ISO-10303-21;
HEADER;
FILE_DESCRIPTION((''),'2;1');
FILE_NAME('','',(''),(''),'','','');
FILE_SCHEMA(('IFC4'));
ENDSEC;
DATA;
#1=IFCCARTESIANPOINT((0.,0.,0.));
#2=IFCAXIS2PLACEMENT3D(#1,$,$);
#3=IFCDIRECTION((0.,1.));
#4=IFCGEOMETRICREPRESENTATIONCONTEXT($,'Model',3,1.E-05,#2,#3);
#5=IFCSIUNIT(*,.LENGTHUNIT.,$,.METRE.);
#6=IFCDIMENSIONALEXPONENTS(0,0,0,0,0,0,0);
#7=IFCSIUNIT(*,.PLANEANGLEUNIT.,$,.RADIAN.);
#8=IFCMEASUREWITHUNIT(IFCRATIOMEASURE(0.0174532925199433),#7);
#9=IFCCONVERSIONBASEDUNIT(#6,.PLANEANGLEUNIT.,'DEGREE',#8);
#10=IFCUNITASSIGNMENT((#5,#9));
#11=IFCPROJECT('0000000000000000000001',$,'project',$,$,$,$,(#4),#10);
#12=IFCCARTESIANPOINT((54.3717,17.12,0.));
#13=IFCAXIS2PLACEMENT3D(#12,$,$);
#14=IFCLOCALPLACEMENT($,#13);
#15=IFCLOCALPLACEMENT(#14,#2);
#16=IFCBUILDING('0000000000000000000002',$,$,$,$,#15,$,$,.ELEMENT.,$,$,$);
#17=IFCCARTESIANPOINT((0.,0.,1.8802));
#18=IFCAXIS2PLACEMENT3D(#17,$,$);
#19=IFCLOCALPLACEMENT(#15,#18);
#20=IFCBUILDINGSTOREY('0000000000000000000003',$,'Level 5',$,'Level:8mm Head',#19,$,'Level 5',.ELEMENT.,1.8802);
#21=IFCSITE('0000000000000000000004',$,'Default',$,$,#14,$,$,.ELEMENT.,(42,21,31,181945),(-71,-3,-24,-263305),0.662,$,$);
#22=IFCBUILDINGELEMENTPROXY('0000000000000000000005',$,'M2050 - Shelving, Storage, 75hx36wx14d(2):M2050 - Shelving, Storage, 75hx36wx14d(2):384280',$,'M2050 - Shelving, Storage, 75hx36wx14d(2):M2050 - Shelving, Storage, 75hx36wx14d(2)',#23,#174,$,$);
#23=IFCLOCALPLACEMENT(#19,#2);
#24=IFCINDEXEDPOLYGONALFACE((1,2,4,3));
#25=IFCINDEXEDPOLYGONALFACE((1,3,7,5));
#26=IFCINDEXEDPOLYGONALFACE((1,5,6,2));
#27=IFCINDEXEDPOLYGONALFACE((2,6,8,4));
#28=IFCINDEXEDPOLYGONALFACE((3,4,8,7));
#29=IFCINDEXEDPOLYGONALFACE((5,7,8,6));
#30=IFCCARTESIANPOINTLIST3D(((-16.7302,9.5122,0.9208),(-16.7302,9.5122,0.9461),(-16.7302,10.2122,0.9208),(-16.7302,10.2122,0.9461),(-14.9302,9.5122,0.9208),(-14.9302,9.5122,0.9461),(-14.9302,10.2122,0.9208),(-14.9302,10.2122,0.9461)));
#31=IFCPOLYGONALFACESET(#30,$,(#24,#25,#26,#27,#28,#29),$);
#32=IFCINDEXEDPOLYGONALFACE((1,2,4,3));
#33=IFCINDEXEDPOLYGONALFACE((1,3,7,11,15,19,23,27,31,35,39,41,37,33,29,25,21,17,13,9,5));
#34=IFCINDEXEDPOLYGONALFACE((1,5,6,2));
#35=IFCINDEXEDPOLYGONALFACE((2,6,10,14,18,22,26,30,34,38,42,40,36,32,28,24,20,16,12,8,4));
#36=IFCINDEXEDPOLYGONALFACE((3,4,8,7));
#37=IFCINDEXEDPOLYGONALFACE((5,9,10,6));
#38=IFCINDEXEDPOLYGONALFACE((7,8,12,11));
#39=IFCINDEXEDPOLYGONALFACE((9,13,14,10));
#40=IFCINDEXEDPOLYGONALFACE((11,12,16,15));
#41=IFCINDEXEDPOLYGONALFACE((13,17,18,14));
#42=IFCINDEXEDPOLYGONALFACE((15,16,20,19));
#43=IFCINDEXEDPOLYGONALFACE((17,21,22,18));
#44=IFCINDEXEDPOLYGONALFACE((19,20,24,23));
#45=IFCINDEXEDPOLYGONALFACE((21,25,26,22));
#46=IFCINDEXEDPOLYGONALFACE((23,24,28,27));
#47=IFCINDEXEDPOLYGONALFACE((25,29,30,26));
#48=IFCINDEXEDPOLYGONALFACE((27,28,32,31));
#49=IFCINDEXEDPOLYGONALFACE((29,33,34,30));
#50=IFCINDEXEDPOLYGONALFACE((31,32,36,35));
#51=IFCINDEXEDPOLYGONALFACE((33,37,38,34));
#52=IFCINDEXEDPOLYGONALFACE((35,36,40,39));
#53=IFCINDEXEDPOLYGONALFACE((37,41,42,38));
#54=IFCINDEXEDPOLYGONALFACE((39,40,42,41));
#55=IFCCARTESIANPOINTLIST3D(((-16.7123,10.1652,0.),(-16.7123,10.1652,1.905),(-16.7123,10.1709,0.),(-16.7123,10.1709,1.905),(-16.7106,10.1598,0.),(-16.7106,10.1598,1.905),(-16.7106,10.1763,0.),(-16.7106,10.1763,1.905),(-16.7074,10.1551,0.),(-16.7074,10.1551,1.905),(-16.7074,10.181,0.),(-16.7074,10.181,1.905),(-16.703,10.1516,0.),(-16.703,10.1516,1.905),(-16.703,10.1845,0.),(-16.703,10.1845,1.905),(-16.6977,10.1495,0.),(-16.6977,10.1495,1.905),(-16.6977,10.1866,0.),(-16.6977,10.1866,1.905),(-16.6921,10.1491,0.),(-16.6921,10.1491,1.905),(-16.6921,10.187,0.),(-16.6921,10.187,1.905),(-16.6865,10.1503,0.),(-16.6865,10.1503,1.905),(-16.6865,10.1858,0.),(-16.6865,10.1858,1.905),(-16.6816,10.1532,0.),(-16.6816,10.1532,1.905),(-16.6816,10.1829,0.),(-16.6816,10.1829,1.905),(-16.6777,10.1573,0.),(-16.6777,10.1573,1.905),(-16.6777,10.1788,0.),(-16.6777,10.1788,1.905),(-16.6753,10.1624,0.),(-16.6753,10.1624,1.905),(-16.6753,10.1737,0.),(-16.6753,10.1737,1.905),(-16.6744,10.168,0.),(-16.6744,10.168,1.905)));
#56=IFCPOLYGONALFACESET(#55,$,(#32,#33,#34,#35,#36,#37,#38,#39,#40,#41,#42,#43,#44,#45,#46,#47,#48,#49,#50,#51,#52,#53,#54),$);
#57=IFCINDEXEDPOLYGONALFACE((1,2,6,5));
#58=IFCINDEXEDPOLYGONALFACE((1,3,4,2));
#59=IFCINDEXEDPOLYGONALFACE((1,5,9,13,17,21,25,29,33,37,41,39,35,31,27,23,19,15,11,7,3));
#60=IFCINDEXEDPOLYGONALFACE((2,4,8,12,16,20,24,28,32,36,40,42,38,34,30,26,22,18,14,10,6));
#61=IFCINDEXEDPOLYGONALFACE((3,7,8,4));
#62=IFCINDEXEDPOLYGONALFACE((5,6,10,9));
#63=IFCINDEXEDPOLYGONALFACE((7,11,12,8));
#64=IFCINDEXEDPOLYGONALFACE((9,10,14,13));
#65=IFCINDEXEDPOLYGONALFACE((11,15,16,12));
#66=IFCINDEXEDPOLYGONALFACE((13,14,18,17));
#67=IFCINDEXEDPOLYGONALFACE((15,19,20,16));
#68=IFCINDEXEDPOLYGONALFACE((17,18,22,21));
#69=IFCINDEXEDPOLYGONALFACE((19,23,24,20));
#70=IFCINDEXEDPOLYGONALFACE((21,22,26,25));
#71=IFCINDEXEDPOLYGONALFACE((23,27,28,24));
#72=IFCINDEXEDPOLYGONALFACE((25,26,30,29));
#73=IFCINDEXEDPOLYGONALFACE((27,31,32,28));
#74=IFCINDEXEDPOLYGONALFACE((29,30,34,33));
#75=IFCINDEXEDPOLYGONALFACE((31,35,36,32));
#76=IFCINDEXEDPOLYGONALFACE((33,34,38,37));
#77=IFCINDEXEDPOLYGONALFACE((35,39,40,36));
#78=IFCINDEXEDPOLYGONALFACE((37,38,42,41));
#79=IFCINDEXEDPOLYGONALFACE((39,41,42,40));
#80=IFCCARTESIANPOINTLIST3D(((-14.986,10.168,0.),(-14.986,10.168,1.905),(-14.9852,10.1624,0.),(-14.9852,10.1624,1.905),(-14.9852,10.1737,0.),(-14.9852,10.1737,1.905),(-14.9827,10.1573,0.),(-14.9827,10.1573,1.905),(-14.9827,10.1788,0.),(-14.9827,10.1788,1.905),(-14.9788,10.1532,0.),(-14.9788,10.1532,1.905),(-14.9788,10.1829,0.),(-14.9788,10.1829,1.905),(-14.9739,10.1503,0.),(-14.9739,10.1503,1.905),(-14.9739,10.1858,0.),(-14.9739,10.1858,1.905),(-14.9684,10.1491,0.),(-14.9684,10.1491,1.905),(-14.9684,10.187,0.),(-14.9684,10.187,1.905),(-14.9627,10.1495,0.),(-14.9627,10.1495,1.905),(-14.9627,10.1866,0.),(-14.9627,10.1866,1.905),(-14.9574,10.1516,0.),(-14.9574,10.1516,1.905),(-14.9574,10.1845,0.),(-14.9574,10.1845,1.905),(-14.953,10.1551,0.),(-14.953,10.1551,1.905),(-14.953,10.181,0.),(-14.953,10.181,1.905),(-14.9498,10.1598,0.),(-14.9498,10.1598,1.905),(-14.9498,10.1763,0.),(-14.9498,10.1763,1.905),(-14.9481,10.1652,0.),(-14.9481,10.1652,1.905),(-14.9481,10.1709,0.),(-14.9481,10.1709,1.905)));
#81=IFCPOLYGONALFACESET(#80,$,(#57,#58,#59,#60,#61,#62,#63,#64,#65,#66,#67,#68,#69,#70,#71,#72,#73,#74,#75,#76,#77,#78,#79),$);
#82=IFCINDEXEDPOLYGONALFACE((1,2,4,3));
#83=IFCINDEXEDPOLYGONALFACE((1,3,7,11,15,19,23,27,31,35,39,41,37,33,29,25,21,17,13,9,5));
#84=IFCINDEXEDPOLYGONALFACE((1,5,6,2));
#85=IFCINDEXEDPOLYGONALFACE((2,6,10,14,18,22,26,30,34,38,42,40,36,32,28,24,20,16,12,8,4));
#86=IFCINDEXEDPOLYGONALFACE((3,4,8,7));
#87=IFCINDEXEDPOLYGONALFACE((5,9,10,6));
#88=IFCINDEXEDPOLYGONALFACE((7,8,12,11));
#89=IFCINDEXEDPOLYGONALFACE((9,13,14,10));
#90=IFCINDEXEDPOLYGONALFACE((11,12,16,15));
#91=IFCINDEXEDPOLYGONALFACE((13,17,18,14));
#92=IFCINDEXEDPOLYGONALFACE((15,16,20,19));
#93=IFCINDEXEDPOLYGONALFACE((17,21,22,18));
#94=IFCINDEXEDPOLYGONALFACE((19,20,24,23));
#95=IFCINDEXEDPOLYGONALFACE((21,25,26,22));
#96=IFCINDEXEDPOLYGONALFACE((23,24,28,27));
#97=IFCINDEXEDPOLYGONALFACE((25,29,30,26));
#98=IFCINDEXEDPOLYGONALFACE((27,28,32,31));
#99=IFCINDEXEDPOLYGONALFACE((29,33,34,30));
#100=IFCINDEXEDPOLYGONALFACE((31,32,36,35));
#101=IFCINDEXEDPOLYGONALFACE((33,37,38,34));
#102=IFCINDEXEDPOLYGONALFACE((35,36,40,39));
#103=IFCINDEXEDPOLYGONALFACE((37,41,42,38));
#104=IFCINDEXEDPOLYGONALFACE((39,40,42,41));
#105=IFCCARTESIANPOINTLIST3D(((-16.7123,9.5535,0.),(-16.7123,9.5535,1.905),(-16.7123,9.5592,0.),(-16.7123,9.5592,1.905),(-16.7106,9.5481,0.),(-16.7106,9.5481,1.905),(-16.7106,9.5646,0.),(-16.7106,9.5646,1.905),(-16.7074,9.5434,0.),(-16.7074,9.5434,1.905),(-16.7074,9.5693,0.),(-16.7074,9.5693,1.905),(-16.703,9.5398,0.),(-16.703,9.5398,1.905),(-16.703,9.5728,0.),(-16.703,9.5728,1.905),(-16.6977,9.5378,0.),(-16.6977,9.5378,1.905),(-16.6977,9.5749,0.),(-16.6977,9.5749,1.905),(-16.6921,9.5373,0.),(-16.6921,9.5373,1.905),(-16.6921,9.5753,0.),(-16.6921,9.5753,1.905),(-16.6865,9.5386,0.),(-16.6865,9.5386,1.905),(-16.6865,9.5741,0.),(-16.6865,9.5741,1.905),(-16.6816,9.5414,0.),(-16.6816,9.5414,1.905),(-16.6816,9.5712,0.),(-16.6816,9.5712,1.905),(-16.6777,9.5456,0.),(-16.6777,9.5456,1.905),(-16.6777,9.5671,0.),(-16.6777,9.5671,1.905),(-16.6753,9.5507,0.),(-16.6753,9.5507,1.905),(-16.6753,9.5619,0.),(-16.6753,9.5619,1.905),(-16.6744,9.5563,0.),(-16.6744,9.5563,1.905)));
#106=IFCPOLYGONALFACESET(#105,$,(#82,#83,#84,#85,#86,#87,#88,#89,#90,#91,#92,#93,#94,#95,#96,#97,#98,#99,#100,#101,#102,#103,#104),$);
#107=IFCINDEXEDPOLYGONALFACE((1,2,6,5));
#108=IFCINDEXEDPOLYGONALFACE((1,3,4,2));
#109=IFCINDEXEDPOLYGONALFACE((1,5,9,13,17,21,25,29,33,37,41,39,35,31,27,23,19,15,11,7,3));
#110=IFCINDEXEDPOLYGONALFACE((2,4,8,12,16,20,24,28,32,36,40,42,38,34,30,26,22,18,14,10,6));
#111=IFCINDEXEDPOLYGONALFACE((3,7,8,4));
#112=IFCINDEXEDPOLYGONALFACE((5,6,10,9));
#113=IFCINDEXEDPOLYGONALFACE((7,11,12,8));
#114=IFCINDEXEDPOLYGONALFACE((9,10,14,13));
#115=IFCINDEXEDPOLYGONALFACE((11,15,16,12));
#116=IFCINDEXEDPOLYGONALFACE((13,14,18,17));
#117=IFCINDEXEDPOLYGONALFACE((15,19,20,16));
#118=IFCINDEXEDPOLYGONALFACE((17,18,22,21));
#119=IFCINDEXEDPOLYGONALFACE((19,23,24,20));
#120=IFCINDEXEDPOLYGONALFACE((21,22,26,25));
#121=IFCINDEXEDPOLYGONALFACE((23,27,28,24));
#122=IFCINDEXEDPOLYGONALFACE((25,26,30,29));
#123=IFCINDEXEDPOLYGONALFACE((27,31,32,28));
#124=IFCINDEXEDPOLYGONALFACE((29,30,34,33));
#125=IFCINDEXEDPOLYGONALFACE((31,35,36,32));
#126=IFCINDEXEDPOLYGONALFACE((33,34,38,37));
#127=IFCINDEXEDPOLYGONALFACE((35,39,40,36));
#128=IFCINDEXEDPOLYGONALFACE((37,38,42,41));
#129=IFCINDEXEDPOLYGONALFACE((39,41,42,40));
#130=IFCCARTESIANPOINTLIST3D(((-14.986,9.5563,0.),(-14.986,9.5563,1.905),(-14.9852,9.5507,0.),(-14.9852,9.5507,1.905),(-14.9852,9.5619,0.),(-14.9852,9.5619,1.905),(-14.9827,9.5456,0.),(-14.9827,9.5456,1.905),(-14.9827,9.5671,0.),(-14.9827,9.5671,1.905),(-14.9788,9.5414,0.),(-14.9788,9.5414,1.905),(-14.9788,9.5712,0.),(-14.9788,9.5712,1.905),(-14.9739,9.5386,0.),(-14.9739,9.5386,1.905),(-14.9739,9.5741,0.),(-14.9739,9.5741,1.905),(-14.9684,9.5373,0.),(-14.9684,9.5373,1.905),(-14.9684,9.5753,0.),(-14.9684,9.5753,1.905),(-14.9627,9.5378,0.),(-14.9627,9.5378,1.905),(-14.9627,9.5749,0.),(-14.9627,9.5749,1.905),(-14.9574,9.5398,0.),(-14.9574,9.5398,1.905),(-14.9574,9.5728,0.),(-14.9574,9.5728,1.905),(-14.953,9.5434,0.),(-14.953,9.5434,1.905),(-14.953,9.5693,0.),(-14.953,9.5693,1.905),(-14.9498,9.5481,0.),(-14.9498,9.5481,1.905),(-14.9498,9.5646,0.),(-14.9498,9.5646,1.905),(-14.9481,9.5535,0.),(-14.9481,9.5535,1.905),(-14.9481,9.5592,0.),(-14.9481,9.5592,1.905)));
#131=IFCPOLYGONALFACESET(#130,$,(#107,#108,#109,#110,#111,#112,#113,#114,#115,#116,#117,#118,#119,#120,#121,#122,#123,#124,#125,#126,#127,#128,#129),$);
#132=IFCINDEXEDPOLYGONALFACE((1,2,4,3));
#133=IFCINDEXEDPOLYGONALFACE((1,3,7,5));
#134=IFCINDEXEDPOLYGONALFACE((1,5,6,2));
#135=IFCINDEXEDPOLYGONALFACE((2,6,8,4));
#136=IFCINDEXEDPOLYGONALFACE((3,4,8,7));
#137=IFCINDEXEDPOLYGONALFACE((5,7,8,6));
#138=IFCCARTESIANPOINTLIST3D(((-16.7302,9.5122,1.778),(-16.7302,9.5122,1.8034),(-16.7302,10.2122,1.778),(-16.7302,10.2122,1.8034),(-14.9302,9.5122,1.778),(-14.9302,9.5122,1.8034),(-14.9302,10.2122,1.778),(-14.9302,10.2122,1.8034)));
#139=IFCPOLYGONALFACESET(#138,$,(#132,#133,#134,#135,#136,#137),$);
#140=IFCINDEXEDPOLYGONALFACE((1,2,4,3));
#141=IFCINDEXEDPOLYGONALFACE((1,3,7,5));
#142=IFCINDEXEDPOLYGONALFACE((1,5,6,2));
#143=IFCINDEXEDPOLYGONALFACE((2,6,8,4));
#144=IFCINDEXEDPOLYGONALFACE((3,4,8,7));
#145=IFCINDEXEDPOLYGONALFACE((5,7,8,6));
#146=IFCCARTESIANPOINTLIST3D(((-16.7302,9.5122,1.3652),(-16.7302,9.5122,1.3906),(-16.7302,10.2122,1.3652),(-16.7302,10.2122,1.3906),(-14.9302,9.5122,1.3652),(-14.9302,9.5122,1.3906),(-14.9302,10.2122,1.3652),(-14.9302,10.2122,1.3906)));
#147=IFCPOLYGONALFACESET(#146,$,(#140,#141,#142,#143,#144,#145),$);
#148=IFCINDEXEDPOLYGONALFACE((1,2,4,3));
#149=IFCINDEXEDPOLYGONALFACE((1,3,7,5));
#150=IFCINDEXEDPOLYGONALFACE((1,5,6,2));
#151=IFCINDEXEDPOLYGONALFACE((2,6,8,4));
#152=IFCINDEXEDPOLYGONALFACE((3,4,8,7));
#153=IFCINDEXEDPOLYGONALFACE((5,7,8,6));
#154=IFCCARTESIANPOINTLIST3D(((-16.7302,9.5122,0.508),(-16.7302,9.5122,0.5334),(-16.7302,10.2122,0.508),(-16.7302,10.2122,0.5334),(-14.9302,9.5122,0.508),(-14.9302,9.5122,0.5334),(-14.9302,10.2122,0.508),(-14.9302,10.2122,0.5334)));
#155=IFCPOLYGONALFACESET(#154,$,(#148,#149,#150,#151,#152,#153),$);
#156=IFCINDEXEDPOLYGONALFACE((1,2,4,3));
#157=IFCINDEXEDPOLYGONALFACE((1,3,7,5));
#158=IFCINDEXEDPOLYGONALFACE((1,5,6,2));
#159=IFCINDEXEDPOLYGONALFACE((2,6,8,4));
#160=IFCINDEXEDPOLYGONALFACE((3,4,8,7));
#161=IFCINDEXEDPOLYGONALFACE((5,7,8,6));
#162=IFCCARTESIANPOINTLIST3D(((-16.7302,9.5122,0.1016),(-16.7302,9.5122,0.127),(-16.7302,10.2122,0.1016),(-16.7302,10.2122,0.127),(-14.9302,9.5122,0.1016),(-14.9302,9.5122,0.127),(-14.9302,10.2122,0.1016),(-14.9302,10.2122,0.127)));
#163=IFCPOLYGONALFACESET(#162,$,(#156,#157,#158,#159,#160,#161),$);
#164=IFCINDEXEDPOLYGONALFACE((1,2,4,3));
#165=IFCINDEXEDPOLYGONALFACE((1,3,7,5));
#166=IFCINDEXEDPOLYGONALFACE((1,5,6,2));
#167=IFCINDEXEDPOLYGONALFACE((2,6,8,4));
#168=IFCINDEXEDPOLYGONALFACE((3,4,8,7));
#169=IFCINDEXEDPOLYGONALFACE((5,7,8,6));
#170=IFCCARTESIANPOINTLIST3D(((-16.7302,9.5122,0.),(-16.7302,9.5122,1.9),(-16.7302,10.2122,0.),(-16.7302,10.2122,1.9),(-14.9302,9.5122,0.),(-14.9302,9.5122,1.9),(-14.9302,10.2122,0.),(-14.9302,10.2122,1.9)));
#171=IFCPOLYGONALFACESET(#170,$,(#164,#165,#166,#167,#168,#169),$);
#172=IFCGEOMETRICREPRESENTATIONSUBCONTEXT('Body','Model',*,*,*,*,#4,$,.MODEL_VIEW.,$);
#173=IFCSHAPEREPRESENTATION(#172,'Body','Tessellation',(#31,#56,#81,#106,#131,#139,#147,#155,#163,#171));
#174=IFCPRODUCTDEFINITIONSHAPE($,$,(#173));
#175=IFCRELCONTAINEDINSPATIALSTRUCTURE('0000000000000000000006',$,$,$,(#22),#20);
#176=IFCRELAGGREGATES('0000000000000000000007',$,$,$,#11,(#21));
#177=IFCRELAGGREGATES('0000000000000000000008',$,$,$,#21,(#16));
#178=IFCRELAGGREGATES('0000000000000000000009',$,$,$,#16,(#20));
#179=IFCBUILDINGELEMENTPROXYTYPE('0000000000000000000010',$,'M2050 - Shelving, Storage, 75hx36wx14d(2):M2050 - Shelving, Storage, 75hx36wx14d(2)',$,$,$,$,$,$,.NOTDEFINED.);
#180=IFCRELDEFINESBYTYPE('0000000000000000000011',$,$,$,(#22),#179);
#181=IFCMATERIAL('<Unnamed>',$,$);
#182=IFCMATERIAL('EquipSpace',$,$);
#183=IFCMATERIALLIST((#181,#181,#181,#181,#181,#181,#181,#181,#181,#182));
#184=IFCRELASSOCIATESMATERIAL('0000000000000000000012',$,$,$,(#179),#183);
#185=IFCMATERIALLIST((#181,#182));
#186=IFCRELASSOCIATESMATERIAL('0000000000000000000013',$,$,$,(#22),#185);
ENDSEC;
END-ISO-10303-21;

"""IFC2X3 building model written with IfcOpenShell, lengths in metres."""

from ifc_helpers import new_model, entity, si_unit, converted_unit, direction, frame, frame_2d, origin, origin_2d_with_axis, place, context, subcontext, project, spatial, rectangle, circle, extrude, source, transform, mapped, material, material_list, type_object, type_shapes, element, save


model = new_model("IFC2X3")

# Units and contexts
model_context = context("Model", 3, precision=1e-05, world=origin(), true_north=direction((0.0, 1.0)))
body_context = subcontext(model_context, "Body", "Model", "MODEL_VIEW")
ifc_project = project(units=[si_unit("LENGTHUNIT", "METRE"), converted_unit("PLANEANGLEUNIT", "DEGREE", entity("IfcRatioMeasure", 0.0174532925199433), si_unit("PLANEANGLEUNIT", "RADIAN"), dimensions=[0, 0, 0, 0, 0, 0, 0])], contexts=[model_context])

# Site, building, storey
site_placement = place(None, frame((54.3717, 17.12, 0.0)))
site = spatial("IfcSite", under=ifc_project, at=site_placement, Name="Default", CompositionType="ELEMENT", RefLatitude=(42, 21, 31, 181945), RefLongitude=(-71, -3, -24, -263305), RefElevation=0.662)
building_placement = place(site_placement, origin())
building = spatial("IfcBuilding", under=site, at=building_placement, CompositionType="ELEMENT")
storey_placement = place(building_placement, frame((0.0, 0.0, 1.8802)))
storey = spatial("IfcBuildingStorey", under=building, at=storey_placement, Name="Level 5", ObjectType="Level:8mm Head", LongName="Level 5", CompositionType="ELEMENT", Elevation=1.8802)

# Building element proxy
ifc_material_1 = material(Name="<Unnamed>")
ifc_material_2 = material(Name="EquipSpace")
ifc_material_list_1 = material_list([ifc_material_1, ifc_material_1, ifc_material_1, ifc_material_1, ifc_material_1, ifc_material_1, ifc_material_1, ifc_material_1, ifc_material_1, ifc_material_2])
building_element_proxy_type = type_object("IfcBuildingElementProxyType", Name="M2050 - Shelving, Storage, 75hx36wx14d(2):M2050 - Shelving, Storage, 75hx36wx14d(2)", PredefinedType="NOTDEFINED", material=ifc_material_list_1)
shared_shape = source(origin(), body_context, "Body", "SweptSolid", [
    extrude(rectangle(XDim=1.8, YDim=0.7, at=origin_2d_with_axis()), frame((0.0, 0.0, 0.9207), z_axis=(0.0, 0.0, 1.0), x_axis=(-1.0, 0.0, 0.0)), (0.0, 0.0, 1.0), 0.0254),
    extrude(circle(Radius=0.0191, at=origin_2d_with_axis()), frame((0.8633, -0.3059, 0.0), z_axis=(0.0, 0.0, 1.0), x_axis=(-1.0, 0.0, 0.0)), (0.0, 0.0, 1.0), 1.905),
    extrude(circle(Radius=0.0191, at=origin_2d_with_axis()), frame((-0.8633, -0.3059, 0.0)), (0.0, 0.0, 1.0), 1.905),
    extrude(circle(Radius=0.0191, at=origin_2d_with_axis()), frame((0.8633, 0.3059, 0.0), z_axis=(0.0, 0.0, 1.0), x_axis=(-1.0, 0.0, 0.0)), (0.0, 0.0, 1.0), 1.905),
    extrude(circle(Radius=0.0191, at=origin_2d_with_axis()), frame((-0.8633, 0.3059, 0.0)), (0.0, 0.0, 1.0), 1.905),
    extrude(rectangle(XDim=1.8, YDim=0.7, at=origin_2d_with_axis()), frame((0.0, 0.0, 1.778), z_axis=(0.0, 0.0, 1.0), x_axis=(-1.0, 0.0, 0.0)), (0.0, 0.0, 1.0), 0.0254),
    extrude(rectangle(XDim=1.8, YDim=0.7, at=origin_2d_with_axis()), frame((0.0, 0.0, 1.3653), z_axis=(0.0, 0.0, 1.0), x_axis=(-1.0, 0.0, 0.0)), (0.0, 0.0, 1.0), 0.0254),
    extrude(rectangle(XDim=1.8, YDim=0.7, at=origin_2d_with_axis()), frame((0.0, 0.0, 0.508), z_axis=(0.0, 0.0, 1.0), x_axis=(-1.0, 0.0, 0.0)), (0.0, 0.0, 1.0), 0.0254),
    extrude(rectangle(XDim=1.8, YDim=0.7, at=origin_2d_with_axis()), frame((0.0, 0.0, 0.1016), z_axis=(0.0, 0.0, 1.0), x_axis=(-1.0, 0.0, 0.0)), (0.0, 0.0, 1.0), 0.0254),
    extrude(rectangle(XDim=0.7, YDim=1.8, at=frame_2d((0.0, 0.18), x_axis=(1.0, 0.0))), frame((-0.18, 0.0, 0.0), z_axis=(0.0, 0.0, 1.0), x_axis=(0.0, -1.0, 0.0)), (0.0, 0.0, 1.0), 1.9),
])
type_shapes(building_element_proxy_type, [shared_shape])
ifc_material_list_2 = material_list([ifc_material_1, ifc_material_2])
proxy_1_placement = place(storey_placement, frame((-15.8302, 9.8622, 0.0), z_axis=(0.0, 0.0, 1.0), x_axis=(-1.0, 0.0, 0.0)))
element("IfcBuildingElementProxy", 1, at=proxy_1_placement, inside=storey, type_object=building_element_proxy_type, material=ifc_material_list_2, Name="M2050 - Shelving, Storage, 75hx36wx14d(2):M2050 - Shelving, Storage, 75hx36wx14d(2):384280", ObjectType="M2050 - Shelving, Storage, 75hx36wx14d(2):M2050 - Shelving, Storage, 75hx36wx14d(2)", context=body_context, shape_type="MappedRepresentation", body=[
    mapped(shared_shape, transform((0.0, 0.0, 0.0), scale=1.0)),
])

save(model, "model.ifc")
